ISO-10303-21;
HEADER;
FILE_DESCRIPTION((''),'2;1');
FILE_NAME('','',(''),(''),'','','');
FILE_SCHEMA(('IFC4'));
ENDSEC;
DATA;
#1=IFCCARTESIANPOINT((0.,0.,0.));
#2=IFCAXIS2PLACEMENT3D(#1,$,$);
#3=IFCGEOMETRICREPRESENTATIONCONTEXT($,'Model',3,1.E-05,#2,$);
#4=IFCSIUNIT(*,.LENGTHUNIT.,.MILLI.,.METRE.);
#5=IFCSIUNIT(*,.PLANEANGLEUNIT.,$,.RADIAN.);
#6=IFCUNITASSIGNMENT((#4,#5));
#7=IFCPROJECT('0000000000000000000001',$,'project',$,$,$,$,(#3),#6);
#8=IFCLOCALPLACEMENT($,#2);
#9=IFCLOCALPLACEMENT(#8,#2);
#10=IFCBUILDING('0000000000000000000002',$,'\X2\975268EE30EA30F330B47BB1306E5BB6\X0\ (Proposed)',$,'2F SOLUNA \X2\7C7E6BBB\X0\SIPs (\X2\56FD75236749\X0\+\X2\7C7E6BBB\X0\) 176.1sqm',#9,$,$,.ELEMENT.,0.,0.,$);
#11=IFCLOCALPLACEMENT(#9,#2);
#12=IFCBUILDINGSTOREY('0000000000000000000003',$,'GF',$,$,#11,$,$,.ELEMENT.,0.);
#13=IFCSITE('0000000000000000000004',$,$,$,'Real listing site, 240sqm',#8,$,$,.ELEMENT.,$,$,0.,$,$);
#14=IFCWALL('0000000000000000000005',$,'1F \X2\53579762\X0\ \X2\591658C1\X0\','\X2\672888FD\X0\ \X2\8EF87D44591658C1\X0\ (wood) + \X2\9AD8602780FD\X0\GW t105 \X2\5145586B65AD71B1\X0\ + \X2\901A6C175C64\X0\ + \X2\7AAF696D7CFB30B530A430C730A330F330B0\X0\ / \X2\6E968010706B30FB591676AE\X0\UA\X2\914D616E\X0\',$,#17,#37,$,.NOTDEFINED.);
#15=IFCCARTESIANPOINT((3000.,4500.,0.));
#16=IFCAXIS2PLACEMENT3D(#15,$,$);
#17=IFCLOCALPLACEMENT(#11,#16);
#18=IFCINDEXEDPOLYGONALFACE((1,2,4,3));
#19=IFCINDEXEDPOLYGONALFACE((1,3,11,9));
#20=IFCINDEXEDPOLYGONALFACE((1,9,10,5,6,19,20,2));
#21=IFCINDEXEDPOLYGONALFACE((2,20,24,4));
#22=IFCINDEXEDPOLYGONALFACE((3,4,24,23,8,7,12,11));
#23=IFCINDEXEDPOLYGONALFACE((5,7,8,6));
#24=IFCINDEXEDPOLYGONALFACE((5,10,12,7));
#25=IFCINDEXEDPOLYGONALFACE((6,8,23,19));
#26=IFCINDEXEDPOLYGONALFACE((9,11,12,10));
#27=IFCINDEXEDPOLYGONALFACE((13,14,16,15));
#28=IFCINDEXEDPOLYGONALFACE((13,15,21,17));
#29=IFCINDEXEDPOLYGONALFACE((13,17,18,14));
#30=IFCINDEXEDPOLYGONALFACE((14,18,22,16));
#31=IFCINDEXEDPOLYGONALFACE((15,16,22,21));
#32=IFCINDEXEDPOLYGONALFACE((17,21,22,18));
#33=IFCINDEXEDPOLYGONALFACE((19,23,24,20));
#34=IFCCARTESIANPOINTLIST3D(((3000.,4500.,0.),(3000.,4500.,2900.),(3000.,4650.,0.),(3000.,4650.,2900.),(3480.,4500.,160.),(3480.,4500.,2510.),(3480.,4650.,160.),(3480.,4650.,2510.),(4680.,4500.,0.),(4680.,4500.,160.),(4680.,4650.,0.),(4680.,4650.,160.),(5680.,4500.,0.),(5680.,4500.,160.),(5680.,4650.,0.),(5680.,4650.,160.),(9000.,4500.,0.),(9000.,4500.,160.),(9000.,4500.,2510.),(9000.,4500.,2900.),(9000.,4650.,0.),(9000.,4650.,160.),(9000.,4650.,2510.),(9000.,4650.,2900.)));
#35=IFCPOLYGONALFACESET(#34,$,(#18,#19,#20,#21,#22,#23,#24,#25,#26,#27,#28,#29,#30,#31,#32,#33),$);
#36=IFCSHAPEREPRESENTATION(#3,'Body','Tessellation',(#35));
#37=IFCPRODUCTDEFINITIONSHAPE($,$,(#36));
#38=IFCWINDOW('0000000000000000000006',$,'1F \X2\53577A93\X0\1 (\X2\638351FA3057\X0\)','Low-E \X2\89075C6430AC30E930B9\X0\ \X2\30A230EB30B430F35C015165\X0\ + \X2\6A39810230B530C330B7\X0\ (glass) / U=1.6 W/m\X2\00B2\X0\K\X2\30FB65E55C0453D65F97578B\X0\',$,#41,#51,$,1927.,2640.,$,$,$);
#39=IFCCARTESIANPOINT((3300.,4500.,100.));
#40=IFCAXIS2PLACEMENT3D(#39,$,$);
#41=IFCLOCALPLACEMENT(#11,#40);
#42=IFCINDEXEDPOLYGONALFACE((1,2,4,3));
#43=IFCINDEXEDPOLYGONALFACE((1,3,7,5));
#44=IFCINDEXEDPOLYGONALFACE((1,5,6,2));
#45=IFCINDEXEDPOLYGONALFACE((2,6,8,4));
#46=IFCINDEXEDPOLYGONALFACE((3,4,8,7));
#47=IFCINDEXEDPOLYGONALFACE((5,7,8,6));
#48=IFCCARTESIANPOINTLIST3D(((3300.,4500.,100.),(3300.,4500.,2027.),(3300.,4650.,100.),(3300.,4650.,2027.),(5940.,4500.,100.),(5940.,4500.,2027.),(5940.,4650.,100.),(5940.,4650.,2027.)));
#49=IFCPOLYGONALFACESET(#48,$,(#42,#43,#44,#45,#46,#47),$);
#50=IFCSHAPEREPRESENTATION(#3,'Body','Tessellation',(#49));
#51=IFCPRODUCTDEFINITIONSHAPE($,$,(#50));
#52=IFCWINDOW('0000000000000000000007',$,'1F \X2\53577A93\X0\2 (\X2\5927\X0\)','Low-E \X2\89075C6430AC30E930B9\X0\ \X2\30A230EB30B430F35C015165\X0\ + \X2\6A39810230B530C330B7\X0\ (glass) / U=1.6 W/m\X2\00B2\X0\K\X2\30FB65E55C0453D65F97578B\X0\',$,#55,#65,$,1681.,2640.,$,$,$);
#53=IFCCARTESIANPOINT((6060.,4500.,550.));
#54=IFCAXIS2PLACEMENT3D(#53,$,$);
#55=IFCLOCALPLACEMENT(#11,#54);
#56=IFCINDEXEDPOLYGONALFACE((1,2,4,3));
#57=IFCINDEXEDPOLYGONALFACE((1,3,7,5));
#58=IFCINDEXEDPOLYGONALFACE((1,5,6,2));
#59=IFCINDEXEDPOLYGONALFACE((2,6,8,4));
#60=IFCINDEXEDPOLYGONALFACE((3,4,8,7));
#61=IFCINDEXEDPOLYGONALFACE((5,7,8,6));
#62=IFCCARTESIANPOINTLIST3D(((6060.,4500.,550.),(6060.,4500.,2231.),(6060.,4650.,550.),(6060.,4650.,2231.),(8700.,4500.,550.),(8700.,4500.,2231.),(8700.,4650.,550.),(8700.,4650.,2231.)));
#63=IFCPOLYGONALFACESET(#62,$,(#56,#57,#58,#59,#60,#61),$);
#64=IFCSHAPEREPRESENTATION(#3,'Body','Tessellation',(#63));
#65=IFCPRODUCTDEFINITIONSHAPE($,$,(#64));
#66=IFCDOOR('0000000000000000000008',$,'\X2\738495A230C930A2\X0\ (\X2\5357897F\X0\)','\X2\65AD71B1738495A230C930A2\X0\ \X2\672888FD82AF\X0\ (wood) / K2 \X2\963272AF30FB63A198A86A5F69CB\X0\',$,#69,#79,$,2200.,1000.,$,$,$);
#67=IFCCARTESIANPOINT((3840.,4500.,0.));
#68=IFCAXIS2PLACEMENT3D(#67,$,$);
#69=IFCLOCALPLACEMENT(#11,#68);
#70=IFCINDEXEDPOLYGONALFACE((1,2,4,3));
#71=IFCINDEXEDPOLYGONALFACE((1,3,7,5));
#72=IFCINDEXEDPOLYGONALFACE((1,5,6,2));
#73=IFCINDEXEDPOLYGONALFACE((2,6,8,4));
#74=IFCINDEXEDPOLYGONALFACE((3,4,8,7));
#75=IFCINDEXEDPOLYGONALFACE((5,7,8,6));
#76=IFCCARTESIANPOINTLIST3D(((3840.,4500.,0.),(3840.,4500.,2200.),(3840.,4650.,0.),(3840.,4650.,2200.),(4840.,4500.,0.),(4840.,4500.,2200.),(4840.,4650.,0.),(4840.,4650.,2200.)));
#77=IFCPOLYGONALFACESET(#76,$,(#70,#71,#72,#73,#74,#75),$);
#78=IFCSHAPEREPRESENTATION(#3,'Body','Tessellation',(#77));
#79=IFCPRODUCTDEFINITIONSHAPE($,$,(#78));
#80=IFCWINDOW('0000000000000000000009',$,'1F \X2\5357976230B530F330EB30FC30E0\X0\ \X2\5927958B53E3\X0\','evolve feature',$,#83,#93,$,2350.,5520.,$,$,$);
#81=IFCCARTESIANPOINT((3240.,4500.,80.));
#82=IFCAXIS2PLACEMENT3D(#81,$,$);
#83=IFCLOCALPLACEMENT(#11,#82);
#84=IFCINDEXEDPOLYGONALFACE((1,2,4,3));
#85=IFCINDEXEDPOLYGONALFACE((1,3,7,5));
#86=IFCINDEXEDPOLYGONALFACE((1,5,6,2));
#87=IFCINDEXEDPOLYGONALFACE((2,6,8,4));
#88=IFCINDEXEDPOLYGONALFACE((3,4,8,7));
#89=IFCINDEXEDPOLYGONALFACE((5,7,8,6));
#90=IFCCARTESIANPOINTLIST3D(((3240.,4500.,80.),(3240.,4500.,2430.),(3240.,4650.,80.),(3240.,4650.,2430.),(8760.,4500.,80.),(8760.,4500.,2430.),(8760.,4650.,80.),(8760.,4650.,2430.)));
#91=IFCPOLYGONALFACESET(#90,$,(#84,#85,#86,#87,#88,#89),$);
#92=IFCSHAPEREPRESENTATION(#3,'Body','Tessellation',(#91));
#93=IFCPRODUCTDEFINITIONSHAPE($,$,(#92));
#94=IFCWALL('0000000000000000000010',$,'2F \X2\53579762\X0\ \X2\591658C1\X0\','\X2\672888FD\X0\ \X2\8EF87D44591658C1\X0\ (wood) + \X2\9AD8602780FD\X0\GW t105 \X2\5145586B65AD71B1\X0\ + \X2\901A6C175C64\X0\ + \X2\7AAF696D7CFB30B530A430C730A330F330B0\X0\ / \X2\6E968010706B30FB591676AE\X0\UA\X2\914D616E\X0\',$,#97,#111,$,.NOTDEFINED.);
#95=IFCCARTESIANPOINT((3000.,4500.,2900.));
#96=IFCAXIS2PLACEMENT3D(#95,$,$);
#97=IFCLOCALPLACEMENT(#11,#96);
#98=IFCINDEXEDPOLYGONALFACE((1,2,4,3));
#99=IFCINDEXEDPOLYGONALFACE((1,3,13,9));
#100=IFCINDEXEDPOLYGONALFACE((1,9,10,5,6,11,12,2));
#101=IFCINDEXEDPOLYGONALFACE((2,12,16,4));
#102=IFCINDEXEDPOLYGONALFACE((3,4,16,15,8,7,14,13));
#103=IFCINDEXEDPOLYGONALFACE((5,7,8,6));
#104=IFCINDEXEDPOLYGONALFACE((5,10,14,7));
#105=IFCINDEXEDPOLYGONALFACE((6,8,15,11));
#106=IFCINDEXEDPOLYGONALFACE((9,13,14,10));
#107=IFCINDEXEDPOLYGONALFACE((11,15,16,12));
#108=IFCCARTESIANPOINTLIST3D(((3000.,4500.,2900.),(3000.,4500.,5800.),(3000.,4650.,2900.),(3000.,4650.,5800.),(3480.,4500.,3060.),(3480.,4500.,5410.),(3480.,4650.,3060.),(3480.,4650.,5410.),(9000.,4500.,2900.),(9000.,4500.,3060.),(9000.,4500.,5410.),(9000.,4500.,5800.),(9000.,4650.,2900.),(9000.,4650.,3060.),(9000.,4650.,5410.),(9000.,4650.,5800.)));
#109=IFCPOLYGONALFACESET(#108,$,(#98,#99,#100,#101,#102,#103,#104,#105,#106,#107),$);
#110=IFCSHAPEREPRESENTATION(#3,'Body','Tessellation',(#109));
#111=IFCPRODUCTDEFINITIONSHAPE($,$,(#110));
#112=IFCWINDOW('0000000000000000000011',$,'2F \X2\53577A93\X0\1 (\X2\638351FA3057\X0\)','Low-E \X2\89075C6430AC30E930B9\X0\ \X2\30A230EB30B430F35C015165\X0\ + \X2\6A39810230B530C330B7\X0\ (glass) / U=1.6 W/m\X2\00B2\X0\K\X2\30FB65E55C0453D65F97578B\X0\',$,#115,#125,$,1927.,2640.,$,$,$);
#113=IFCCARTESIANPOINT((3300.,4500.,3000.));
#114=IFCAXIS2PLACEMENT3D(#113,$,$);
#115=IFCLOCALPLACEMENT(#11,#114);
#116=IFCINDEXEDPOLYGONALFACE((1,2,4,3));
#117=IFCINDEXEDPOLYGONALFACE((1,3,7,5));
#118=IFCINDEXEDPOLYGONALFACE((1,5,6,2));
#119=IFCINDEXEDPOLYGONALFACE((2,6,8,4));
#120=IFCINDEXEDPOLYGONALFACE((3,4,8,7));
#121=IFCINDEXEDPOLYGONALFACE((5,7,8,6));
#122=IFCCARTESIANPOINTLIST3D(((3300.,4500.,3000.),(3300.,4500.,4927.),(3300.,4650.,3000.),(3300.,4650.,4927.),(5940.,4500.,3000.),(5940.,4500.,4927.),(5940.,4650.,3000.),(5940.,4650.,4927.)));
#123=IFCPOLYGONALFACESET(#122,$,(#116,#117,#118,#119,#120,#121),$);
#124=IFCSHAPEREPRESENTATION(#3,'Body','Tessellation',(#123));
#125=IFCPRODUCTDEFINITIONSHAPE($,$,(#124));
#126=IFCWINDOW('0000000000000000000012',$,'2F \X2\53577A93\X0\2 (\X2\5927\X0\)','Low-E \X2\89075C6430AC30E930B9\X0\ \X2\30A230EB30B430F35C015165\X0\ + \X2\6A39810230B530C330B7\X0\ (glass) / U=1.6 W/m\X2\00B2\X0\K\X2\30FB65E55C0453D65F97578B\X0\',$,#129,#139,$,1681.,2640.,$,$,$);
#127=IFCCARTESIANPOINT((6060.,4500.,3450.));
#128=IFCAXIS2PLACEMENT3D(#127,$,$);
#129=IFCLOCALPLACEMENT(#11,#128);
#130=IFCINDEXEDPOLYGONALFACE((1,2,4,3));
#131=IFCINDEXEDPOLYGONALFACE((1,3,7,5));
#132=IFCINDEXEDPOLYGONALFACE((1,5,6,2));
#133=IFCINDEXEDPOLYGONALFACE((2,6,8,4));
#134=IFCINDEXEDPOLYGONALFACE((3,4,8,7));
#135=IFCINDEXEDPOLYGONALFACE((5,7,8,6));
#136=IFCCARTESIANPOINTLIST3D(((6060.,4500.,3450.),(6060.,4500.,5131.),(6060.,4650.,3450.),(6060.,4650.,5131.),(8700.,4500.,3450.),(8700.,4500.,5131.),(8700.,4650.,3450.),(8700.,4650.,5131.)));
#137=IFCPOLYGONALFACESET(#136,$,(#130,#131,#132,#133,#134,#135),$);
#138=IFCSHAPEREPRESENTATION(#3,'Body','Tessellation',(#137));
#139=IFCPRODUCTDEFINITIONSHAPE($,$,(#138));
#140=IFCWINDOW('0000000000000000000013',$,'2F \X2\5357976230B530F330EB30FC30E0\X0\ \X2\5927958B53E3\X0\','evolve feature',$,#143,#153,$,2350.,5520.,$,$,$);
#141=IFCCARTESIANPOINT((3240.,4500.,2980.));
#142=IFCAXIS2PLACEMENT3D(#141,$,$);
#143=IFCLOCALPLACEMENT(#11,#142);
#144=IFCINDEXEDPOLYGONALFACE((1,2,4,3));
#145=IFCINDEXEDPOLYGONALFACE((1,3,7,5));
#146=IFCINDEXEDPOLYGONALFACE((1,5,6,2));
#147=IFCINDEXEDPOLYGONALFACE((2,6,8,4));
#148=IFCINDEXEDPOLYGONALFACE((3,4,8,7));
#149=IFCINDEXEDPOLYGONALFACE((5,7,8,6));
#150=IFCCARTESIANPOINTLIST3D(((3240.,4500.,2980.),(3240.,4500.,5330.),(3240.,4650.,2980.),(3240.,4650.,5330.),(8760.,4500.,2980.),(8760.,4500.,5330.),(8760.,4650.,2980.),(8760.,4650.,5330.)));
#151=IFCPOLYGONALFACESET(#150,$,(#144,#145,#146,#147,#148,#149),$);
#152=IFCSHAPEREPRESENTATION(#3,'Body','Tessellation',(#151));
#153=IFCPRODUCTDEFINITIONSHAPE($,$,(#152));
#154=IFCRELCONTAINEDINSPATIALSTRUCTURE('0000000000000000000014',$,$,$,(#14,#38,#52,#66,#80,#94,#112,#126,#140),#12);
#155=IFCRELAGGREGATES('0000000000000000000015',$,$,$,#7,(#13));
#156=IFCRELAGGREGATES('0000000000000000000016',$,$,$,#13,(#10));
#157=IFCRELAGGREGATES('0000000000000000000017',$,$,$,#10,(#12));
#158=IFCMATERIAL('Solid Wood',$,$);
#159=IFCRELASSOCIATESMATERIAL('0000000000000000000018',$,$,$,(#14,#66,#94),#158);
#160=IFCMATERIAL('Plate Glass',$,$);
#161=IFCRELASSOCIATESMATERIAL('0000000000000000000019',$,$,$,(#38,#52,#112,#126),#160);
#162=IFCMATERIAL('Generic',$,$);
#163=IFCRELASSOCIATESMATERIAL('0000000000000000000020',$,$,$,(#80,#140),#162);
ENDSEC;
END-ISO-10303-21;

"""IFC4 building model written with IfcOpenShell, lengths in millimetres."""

from ifc_helpers import new_model, si_unit, frame, frame_2d, origin, place, context, project, spatial, rectangle, extrude, material, element, fill, save


model = new_model("IFC4")

# Units and contexts
model_context = context("Model", 3, precision=1e-05, world=origin())
ifc_project = project(units=[si_unit("LENGTHUNIT", "METRE", prefix="MILLI"), si_unit("PLANEANGLEUNIT", "RADIAN")], contexts=[model_context])

# Site, building, storey
site_placement = place(None, origin())
site = spatial("IfcSite", under=ifc_project, at=site_placement, ObjectType="Real listing site, 240sqm", CompositionType="ELEMENT", RefElevation=0.0)
building_placement = place(site_placement, origin())
building = spatial("IfcBuilding", under=site, at=building_placement, Name="青森リンゴ箱の家 (Proposed)", ObjectType="2F SOLUNA 籾殻SIPs (国産杉+籾殻) 176.1sqm", CompositionType="ELEMENT", ElevationOfRefHeight=0.0, ElevationOfTerrain=0.0)
storey_placement = place(building_placement, origin())
storey = spatial("IfcBuildingStorey", under=building, at=storey_placement, Name="GF", CompositionType="ELEMENT", Elevation=0.0)

# Shared definitions
ifc_material_1 = material(Name="Solid Wood")
ifc_material_2 = material(Name="Generic")

# Wall, openings, windows, door
wall_1_placement = place(storey_placement, frame((3000.0, 4500.0, 0.0)))
wall_1 = element("IfcWall", 1, at=wall_1_placement, inside=storey, material=ifc_material_1, Name="1F 南面 外壁", Description="木製 軸組外壁 (wood) + 高性能GW t105 充填断熱 + 通気層 + 窯業系サイディング / 準耐火・外皮UA配慮", PredefinedType="NOTDEFINED", context=model_context, shape_type="SweptSolid", body=[
    extrude(rectangle(XDim=6000.0, YDim=150.0, at=frame_2d((3000.0, 75.0))), frame((3000.0, 4500.0, 0.0)), (0.0, 0.0, 1.0), 2900.0),
])
opening_1_placement = place(storey_placement, frame((3300.0, 4500.0, 100.0)))
opening_1 = element("IfcOpeningElement", 2, at=opening_1_placement, cuts=wall_1, PredefinedType="NOTDEFINED", context=model_context, shape_type="SweptSolid", body=[
    extrude(rectangle(XDim=2640.0, YDim=150.0, at=frame_2d((1320.0, 75.0))), frame((3300.0, 4500.0, 100.0)), (0.0, 0.0, 1.0), 1927.0),
])
opening_2_placement = place(storey_placement, frame((6060.0, 4500.0, 550.0)))
opening_2 = element("IfcOpeningElement", 3, at=opening_2_placement, cuts=wall_1, PredefinedType="NOTDEFINED", context=model_context, shape_type="SweptSolid", body=[
    extrude(rectangle(XDim=2640.0, YDim=150.0, at=frame_2d((1320.0, 75.0))), frame((6060.0, 4500.0, 550.0)), (0.0, 0.0, 1.0), 1681.0),
])
opening_3_placement = place(storey_placement, frame((3840.0, 4500.0, 0.0)))
opening_3 = element("IfcOpeningElement", 4, at=opening_3_placement, cuts=wall_1, PredefinedType="NOTDEFINED", context=model_context, shape_type="SweptSolid", body=[
    extrude(rectangle(XDim=1000.0, YDim=150.0, at=frame_2d((500.0, 75.0))), frame((3840.0, 4500.0, 0.0)), (0.0, 0.0, 1.0), 2200.0),
])
opening_4_placement = place(storey_placement, frame((3240.0, 4500.0, 80.0)))
opening_4 = element("IfcOpeningElement", 5, at=opening_4_placement, cuts=wall_1, PredefinedType="NOTDEFINED", context=model_context, shape_type="SweptSolid", body=[
    extrude(rectangle(XDim=5520.0, YDim=150.0, at=frame_2d((2760.0, 75.0))), frame((3240.0, 4500.0, 80.0)), (0.0, 0.0, 1.0), 2350.0),
])
ifc_material_3 = material(Name="Plate Glass")
window_1_placement = place(storey_placement, frame((3300.0, 4500.0, 100.0)))
window_1 = element("IfcWindow", 6, at=window_1_placement, inside=storey, material=ifc_material_3, Name="1F 南窓1 (掃出し)", Description="Low-E 複層ガラス アルゴン封入 + 樹脂サッシ (glass) / U=1.6 W/m²K・日射取得型", OverallHeight=1927.0, OverallWidth=2640.0, context=model_context, shape_type="SweptSolid", body=[
    extrude(rectangle(XDim=2640.0, YDim=150.0, at=frame_2d((1320.0, 75.0))), frame((3300.0, 4500.0, 100.0)), (0.0, 0.0, 1.0), 1927.0),
])
fill(opening_1, window_1)
window_2_placement = place(storey_placement, frame((6060.0, 4500.0, 550.0)))
window_2 = element("IfcWindow", 7, at=window_2_placement, inside=storey, material=ifc_material_3, Name="1F 南窓2 (大)", Description="Low-E 複層ガラス アルゴン封入 + 樹脂サッシ (glass) / U=1.6 W/m²K・日射取得型", OverallHeight=1681.0, OverallWidth=2640.0, context=model_context, shape_type="SweptSolid", body=[
    extrude(rectangle(XDim=2640.0, YDim=150.0, at=frame_2d((1320.0, 75.0))), frame((6060.0, 4500.0, 550.0)), (0.0, 0.0, 1.0), 1681.0),
])
fill(opening_2, window_2)
door_placement = place(storey_placement, frame((3840.0, 4500.0, 0.0)))
door = element("IfcDoor", 8, at=door_placement, inside=storey, material=ifc_material_1, Name="玄関ドア (南西)", Description="断熱玄関ドア 木製芯 (wood) / K2 防犯・採風機構", OverallHeight=2200.0, OverallWidth=1000.0, context=model_context, shape_type="SweptSolid", body=[
    extrude(rectangle(XDim=1000.0, YDim=150.0, at=frame_2d((500.0, 75.0))), frame((3840.0, 4500.0, 0.0)), (0.0, 0.0, 1.0), 2200.0),
])
fill(opening_3, door)
window_3_placement = place(storey_placement, frame((3240.0, 4500.0, 80.0)))
window_3 = element("IfcWindow", 9, at=window_3_placement, inside=storey, material=ifc_material_2, Name="1F 南面サンルーム 大開口", Description="evolve feature", OverallHeight=2350.0, OverallWidth=5520.0, context=model_context, shape_type="SweptSolid", body=[
    extrude(rectangle(XDim=5520.0, YDim=150.0, at=frame_2d((2760.0, 75.0))), frame((3240.0, 4500.0, 80.0)), (0.0, 0.0, 1.0), 2350.0),
])
fill(opening_4, window_3)

# Wall, openings, windows
wall_2_placement = place(storey_placement, frame((3000.0, 4500.0, 2900.0)))
wall_2 = element("IfcWall", 10, at=wall_2_placement, inside=storey, material=ifc_material_1, Name="2F 南面 外壁", Description="木製 軸組外壁 (wood) + 高性能GW t105 充填断熱 + 通気層 + 窯業系サイディング / 準耐火・外皮UA配慮", PredefinedType="NOTDEFINED", context=model_context, shape_type="SweptSolid", body=[
    extrude(rectangle(XDim=6000.0, YDim=150.0, at=frame_2d((3000.0, 75.0))), frame((3000.0, 4500.0, 2900.0)), (0.0, 0.0, 1.0), 2900.0),
])
opening_5_placement = place(storey_placement, frame((3300.0, 4500.0, 3000.0)))
opening_5 = element("IfcOpeningElement", 11, at=opening_5_placement, cuts=wall_2, PredefinedType="NOTDEFINED", context=model_context, shape_type="SweptSolid", body=[
    extrude(rectangle(XDim=2640.0, YDim=150.0, at=frame_2d((1320.0, 75.0))), frame((3300.0, 4500.0, 3000.0)), (0.0, 0.0, 1.0), 1927.0),
])
opening_6_placement = place(storey_placement, frame((6060.0, 4500.0, 3450.0)))
opening_6 = element("IfcOpeningElement", 12, at=opening_6_placement, cuts=wall_2, PredefinedType="NOTDEFINED", context=model_context, shape_type="SweptSolid", body=[
    extrude(rectangle(XDim=2640.0, YDim=150.0, at=frame_2d((1320.0, 75.0))), frame((6060.0, 4500.0, 3450.0)), (0.0, 0.0, 1.0), 1681.0),
])
opening_7_placement = place(storey_placement, frame((3240.0, 4500.0, 2980.0)))
opening_7 = element("IfcOpeningElement", 13, at=opening_7_placement, cuts=wall_2, PredefinedType="NOTDEFINED", context=model_context, shape_type="SweptSolid", body=[
    extrude(rectangle(XDim=5520.0, YDim=150.0, at=frame_2d((2760.0, 75.0))), frame((3240.0, 4500.0, 2980.0)), (0.0, 0.0, 1.0), 2350.0),
])
window_4_placement = place(storey_placement, frame((3300.0, 4500.0, 3000.0)))
window_4 = element("IfcWindow", 14, at=window_4_placement, inside=storey, material=ifc_material_3, Name="2F 南窓1 (掃出し)", Description="Low-E 複層ガラス アルゴン封入 + 樹脂サッシ (glass) / U=1.6 W/m²K・日射取得型", OverallHeight=1927.0, OverallWidth=2640.0, context=model_context, shape_type="SweptSolid", body=[
    extrude(rectangle(XDim=2640.0, YDim=150.0, at=frame_2d((1320.0, 75.0))), frame((3300.0, 4500.0, 3000.0)), (0.0, 0.0, 1.0), 1927.0),
])
fill(opening_5, window_4)
window_5_placement = place(storey_placement, frame((6060.0, 4500.0, 3450.0)))
window_5 = element("IfcWindow", 15, at=window_5_placement, inside=storey, material=ifc_material_3, Name="2F 南窓2 (大)", Description="Low-E 複層ガラス アルゴン封入 + 樹脂サッシ (glass) / U=1.6 W/m²K・日射取得型", OverallHeight=1681.0, OverallWidth=2640.0, context=model_context, shape_type="SweptSolid", body=[
    extrude(rectangle(XDim=2640.0, YDim=150.0, at=frame_2d((1320.0, 75.0))), frame((6060.0, 4500.0, 3450.0)), (0.0, 0.0, 1.0), 1681.0),
])
fill(opening_6, window_5)
window_6_placement = place(storey_placement, frame((3240.0, 4500.0, 2980.0)))
window_6 = element("IfcWindow", 16, at=window_6_placement, inside=storey, material=ifc_material_2, Name="2F 南面サンルーム 大開口", Description="evolve feature", OverallHeight=2350.0, OverallWidth=5520.0, context=model_context, shape_type="SweptSolid", body=[
    extrude(rectangle(XDim=5520.0, YDim=150.0, at=frame_2d((2760.0, 75.0))), frame((3240.0, 4500.0, 2980.0)), (0.0, 0.0, 1.0), 2350.0),
])
fill(opening_7, window_6)

save(model, "model.ifc")
